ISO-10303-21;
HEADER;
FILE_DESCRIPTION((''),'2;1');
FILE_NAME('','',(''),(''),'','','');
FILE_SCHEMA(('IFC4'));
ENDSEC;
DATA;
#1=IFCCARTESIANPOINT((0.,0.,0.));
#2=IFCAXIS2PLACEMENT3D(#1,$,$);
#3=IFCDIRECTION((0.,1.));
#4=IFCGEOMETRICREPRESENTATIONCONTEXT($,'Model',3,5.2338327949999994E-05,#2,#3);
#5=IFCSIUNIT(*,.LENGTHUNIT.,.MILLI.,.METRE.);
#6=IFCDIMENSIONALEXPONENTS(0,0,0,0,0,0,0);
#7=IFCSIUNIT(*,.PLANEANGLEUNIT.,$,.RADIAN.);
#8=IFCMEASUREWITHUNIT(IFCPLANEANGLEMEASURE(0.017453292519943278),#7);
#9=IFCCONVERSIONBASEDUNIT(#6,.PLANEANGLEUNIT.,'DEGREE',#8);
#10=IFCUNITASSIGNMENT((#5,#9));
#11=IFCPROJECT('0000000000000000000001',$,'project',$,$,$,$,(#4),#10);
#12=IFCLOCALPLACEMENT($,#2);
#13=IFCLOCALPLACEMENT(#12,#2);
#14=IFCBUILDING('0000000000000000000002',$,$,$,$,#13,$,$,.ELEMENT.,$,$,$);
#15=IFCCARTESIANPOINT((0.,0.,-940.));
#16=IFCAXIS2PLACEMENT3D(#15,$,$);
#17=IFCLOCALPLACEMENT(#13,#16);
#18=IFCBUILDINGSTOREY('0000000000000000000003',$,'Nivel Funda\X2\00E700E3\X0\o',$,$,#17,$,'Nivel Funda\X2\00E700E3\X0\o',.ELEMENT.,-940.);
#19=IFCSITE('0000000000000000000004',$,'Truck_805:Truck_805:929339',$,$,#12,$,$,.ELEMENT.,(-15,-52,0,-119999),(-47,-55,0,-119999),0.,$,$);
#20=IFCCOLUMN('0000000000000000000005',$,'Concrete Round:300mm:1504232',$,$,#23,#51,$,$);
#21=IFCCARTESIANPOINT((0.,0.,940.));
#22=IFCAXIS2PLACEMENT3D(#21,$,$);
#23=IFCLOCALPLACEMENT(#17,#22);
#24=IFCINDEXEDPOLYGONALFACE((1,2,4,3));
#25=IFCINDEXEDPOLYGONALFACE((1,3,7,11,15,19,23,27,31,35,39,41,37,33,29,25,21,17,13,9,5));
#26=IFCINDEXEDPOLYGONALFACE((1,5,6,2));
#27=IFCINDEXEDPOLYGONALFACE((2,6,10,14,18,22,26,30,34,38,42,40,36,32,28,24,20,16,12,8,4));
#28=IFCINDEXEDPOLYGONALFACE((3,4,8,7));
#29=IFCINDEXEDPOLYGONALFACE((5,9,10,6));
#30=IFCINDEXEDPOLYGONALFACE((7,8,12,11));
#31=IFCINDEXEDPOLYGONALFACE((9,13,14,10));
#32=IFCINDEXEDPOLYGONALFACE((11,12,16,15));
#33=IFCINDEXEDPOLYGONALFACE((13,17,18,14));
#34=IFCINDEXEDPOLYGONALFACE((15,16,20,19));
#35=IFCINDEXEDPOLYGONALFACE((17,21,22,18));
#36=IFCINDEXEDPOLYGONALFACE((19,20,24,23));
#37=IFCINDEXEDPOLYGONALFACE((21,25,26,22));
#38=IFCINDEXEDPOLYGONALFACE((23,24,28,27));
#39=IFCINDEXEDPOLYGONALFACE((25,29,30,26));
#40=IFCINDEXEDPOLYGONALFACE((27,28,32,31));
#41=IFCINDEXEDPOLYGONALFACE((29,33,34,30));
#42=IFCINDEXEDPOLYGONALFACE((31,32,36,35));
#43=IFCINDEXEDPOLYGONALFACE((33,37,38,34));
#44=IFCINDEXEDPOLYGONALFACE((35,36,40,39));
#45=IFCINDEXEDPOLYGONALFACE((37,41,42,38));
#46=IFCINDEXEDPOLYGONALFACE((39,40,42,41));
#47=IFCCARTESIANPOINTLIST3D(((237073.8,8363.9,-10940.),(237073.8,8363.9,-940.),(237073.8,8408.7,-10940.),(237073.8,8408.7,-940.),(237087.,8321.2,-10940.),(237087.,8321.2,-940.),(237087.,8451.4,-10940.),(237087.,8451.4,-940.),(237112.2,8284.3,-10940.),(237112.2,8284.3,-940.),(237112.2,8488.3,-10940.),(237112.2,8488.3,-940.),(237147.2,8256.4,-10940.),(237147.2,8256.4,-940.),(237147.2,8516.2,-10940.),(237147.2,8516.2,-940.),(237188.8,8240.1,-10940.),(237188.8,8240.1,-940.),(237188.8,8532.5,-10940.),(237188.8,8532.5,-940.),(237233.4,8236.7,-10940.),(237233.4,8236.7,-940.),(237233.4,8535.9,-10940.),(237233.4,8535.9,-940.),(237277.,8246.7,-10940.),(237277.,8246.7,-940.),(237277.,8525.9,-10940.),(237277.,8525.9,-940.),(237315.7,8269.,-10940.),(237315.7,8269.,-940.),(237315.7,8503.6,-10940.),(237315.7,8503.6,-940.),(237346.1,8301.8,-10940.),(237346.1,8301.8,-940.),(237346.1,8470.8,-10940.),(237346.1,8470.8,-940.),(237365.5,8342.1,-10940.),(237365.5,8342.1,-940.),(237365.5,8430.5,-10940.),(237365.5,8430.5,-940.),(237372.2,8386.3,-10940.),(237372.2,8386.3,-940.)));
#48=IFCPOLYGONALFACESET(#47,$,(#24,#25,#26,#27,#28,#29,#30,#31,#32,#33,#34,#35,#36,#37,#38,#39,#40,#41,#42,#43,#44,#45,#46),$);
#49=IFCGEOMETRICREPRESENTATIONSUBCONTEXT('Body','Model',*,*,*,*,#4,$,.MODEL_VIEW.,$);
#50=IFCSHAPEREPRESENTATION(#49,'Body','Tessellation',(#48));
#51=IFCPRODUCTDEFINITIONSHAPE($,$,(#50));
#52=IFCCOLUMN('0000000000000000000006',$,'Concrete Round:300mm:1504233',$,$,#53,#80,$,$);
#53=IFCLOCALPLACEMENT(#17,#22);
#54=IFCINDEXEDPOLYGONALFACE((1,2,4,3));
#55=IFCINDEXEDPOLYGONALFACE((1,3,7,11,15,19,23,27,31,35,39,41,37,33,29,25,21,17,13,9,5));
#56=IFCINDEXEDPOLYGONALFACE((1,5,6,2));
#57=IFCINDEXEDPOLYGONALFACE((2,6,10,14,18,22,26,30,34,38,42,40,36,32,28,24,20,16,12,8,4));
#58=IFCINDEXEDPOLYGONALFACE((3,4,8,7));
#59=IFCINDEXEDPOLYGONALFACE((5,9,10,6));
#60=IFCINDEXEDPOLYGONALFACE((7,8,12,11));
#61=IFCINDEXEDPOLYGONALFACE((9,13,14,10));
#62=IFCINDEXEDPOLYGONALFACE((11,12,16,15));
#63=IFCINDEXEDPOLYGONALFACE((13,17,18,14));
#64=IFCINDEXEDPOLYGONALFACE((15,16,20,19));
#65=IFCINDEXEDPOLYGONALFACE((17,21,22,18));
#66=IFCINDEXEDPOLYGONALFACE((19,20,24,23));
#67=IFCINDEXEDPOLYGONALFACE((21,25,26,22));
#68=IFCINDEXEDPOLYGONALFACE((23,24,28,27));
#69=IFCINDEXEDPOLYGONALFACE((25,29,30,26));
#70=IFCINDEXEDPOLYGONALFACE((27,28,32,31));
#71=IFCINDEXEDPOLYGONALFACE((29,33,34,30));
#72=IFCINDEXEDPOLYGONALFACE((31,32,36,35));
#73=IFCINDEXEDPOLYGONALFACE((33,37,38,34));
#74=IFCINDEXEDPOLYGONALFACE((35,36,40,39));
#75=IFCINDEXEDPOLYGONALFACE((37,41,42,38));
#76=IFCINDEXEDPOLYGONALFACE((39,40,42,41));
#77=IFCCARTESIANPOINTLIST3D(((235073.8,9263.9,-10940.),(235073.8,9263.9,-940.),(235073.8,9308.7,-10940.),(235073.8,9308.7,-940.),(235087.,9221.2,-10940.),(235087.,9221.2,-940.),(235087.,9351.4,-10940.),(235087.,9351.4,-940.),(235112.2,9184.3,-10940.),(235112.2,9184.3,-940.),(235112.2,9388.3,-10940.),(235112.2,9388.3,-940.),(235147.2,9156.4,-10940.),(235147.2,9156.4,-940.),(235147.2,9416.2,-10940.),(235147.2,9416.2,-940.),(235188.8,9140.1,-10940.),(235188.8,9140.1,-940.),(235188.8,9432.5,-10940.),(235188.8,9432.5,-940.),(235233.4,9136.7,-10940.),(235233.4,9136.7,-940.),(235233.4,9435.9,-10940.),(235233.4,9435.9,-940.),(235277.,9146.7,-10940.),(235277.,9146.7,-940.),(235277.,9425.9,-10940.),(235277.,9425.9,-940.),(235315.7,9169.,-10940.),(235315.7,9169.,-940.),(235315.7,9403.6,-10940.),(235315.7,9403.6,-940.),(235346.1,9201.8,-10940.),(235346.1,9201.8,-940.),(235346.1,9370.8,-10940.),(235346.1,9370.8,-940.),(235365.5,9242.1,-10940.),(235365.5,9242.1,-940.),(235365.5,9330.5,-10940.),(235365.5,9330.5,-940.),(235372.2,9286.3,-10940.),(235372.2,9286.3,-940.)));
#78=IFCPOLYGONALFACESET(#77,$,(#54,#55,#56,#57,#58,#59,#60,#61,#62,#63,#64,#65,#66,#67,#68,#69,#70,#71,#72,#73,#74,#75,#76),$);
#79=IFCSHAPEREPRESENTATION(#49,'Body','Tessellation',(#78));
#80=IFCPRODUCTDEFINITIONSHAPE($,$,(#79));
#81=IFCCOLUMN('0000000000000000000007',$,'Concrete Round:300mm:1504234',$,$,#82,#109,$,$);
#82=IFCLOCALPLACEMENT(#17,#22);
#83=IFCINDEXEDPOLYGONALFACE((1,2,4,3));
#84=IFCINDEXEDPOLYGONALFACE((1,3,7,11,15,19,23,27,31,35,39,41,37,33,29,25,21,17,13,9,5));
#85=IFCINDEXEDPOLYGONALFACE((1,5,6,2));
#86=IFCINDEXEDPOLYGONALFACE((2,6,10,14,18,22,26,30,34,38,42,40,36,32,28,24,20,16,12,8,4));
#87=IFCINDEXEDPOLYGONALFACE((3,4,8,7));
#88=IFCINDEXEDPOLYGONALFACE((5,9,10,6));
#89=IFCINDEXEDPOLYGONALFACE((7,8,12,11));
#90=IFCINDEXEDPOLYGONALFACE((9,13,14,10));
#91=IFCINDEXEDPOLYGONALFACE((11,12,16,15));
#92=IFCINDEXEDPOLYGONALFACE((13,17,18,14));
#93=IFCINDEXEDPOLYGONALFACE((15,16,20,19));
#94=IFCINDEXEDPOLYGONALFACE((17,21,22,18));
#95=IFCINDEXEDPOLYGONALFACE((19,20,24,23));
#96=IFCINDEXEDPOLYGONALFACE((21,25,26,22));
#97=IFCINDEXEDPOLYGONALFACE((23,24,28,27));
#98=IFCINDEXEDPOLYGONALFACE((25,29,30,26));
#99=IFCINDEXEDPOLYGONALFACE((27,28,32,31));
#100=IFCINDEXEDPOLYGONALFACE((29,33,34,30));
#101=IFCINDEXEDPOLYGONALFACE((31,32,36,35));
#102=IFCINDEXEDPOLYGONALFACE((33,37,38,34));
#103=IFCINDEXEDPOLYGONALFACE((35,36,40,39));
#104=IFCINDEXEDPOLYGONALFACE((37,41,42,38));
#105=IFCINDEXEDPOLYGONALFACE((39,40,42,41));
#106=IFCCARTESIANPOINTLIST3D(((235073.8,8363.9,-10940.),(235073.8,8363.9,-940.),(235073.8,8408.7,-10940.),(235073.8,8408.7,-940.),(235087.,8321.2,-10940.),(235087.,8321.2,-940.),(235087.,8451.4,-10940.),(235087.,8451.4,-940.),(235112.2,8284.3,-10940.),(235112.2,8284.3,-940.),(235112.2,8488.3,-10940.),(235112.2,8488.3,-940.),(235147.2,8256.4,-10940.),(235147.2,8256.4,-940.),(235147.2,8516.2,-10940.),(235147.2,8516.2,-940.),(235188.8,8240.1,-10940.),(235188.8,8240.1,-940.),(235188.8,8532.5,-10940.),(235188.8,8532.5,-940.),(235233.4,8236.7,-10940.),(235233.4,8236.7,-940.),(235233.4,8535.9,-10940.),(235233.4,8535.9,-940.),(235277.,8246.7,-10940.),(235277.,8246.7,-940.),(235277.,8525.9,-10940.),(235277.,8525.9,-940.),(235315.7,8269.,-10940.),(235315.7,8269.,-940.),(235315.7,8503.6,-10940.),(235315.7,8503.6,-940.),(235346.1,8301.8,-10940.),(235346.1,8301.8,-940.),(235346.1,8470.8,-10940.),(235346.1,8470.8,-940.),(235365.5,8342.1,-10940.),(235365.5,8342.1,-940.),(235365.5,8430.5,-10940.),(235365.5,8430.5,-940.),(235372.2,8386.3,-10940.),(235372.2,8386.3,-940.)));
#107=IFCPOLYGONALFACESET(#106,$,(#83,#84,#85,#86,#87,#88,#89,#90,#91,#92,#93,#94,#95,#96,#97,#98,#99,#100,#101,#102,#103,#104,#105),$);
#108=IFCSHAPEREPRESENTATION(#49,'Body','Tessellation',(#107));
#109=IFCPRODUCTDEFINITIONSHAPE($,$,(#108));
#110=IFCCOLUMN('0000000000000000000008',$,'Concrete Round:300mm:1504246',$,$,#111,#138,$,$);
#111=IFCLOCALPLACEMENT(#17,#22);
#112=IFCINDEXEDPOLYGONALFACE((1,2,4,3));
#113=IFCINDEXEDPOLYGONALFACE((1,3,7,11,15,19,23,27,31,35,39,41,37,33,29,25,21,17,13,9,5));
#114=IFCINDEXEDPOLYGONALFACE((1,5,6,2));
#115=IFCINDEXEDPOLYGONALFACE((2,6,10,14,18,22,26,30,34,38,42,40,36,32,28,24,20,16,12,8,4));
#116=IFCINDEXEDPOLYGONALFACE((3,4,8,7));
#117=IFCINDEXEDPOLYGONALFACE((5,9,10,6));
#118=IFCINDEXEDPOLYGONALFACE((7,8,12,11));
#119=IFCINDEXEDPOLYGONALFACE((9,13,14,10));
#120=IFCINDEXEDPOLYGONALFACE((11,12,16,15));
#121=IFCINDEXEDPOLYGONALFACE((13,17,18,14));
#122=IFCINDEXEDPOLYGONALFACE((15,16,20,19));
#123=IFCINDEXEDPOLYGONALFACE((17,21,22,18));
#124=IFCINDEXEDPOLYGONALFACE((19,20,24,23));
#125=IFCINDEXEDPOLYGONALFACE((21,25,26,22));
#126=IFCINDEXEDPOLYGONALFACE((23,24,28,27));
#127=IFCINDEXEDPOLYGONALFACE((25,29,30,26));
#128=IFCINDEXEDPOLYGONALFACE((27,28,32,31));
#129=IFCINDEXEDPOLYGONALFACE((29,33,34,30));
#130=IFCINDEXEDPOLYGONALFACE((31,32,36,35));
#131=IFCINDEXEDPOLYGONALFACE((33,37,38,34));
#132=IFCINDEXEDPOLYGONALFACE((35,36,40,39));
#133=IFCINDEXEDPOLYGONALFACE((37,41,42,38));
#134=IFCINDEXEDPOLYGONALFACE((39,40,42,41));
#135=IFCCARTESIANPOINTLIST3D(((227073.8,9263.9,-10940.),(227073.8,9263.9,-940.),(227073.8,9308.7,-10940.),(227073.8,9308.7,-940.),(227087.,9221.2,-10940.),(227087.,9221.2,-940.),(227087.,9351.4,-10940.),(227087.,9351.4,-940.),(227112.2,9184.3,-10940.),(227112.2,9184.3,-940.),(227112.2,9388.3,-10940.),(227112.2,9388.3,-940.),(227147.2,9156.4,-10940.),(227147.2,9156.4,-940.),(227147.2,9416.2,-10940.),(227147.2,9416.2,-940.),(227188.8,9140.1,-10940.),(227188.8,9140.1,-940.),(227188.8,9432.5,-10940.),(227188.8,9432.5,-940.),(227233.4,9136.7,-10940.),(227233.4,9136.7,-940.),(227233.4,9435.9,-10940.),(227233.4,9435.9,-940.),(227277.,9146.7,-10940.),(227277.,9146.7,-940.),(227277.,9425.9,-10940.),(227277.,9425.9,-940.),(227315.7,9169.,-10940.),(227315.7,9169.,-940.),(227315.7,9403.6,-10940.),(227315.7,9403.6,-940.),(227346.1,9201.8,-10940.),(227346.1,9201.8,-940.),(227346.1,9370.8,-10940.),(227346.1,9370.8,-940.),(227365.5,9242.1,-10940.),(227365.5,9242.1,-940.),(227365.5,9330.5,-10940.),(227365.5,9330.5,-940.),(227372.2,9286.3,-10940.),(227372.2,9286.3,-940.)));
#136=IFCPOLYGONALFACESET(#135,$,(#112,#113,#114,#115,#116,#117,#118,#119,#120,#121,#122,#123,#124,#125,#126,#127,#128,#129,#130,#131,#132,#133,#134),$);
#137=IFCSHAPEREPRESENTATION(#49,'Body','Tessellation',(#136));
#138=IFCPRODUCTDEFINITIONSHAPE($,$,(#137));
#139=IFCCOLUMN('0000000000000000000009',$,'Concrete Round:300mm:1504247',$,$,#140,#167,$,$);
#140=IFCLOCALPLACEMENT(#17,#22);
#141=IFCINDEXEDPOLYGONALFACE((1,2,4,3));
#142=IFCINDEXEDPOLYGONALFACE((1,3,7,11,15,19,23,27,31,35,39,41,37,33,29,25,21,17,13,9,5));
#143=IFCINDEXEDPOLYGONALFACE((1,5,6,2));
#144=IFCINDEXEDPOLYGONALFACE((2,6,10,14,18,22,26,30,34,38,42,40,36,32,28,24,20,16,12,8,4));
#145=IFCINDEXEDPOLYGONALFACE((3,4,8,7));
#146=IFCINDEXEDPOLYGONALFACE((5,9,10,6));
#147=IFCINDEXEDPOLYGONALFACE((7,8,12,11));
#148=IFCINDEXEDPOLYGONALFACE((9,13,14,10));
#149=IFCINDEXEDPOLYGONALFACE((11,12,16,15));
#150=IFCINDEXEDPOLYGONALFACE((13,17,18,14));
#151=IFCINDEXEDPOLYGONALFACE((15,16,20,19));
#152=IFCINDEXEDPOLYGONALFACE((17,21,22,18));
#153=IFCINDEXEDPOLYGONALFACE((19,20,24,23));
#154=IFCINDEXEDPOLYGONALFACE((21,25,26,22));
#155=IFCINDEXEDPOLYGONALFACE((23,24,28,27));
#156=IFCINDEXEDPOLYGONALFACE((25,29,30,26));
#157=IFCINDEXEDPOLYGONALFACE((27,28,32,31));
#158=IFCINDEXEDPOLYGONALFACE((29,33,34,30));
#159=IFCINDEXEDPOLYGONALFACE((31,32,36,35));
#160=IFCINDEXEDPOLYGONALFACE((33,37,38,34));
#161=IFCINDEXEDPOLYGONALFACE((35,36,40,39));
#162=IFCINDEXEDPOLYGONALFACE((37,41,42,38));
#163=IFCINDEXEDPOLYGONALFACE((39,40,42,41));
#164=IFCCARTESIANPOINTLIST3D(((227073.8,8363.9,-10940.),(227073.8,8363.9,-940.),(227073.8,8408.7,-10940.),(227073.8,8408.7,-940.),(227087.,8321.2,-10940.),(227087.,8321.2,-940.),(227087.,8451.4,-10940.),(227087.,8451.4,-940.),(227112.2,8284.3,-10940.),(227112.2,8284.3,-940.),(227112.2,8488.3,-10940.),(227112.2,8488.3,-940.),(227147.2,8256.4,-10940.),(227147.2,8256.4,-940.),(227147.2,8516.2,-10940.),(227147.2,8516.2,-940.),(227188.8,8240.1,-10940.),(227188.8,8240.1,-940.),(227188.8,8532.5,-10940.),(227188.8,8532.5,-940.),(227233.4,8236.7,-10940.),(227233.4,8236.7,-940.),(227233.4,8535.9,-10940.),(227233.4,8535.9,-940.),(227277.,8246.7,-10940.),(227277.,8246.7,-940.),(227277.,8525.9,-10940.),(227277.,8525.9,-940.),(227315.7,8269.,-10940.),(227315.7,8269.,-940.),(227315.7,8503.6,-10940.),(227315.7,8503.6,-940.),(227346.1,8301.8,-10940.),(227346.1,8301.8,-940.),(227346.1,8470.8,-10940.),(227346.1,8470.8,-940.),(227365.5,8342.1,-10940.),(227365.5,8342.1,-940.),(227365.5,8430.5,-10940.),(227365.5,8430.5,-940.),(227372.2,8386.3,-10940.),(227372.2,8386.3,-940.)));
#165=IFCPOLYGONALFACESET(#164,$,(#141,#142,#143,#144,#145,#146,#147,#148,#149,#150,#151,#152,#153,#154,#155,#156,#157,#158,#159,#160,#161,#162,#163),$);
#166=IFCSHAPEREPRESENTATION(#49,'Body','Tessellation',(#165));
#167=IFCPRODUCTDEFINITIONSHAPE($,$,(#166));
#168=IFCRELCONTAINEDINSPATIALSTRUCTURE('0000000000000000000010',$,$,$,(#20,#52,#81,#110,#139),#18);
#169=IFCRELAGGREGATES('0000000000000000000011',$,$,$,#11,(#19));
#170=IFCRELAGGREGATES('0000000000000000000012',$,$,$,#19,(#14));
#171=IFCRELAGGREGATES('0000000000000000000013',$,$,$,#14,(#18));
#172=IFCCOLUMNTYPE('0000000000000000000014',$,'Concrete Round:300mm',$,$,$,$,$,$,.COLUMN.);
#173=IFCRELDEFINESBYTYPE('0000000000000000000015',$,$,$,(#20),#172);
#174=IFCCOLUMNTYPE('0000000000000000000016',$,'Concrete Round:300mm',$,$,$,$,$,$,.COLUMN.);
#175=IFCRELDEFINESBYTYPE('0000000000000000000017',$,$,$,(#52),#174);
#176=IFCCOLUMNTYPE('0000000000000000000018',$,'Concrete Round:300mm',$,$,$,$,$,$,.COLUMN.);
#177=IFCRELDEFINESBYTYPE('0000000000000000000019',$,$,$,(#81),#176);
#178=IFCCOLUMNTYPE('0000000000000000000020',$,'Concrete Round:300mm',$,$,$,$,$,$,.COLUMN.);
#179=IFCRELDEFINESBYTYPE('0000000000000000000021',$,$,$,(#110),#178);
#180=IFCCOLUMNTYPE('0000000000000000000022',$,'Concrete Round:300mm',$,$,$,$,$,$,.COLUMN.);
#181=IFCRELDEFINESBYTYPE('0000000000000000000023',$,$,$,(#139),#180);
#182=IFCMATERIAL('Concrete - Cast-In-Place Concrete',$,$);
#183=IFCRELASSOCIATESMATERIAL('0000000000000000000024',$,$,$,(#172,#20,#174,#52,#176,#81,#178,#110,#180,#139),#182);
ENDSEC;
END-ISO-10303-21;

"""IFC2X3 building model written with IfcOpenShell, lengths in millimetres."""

from ifc_helpers import new_model, entity, si_unit, converted_unit, direction, frame, origin, origin_2d_with_axis, place, context, subcontext, project, spatial, circle, extrude, source, transform, mapped, material, type_object, type_shapes, element, save


model = new_model("IFC2X3")

# Units and contexts
model_context = context("Model", 3, precision=5.2338327949999994e-05, world=origin(), true_north=direction((0.0, 1.0)))
body_context = subcontext(model_context, "Body", "Model", "MODEL_VIEW")
ifc_project = project(units=[si_unit("LENGTHUNIT", "METRE", prefix="MILLI"), converted_unit("PLANEANGLEUNIT", "DEGREE", entity("IfcPlaneAngleMeasure", 0.017453292519943278), si_unit("PLANEANGLEUNIT", "RADIAN"), dimensions=[0, 0, 0, 0, 0, 0, 0])], contexts=[model_context])

# Site, building, storey
site_placement = place(None, origin())
site = spatial("IfcSite", under=ifc_project, at=site_placement, Name="Truck_805:Truck_805:929339", CompositionType="ELEMENT", RefLatitude=(-15, -52, 0, -119999), RefLongitude=(-47, -55, 0, -119999), RefElevation=0.0)
building_placement = place(site_placement, origin())
building = spatial("IfcBuilding", under=site, at=building_placement, CompositionType="ELEMENT")
storey_placement = place(building_placement, frame((0.0, 0.0, -940.0)))
storey = spatial("IfcBuildingStorey", under=building, at=storey_placement, Name="Nivel Fundação", LongName="Nivel Fundação", CompositionType="ELEMENT", Elevation=-940.0)

# Columns
ifc_material = material(Name="Concrete - Cast-In-Place Concrete")
column_type_1 = type_object("IfcColumnType", Name="Concrete Round:300mm", PredefinedType="COLUMN", material=ifc_material)
shared_shape_1 = source(origin(), body_context, "Body", "SweptSolid", [
    extrude(circle(Radius=150.0, at=origin_2d_with_axis()), frame((237222.2, 8386.3, -10940.0)), (0.0, 0.0, 1.0), 10000.0),
])
type_shapes(column_type_1, [shared_shape_1])
column_1_placement = place(storey_placement, frame((0.0, 0.0, 940.0)))
element("IfcColumn", 1, at=column_1_placement, inside=storey, type_object=column_type_1, material=ifc_material, Name="Concrete Round:300mm:1504232", context=body_context, shape_type="MappedRepresentation", body=[
    mapped(shared_shape_1, transform((0.0, 0.0, 0.0), scale=1.0)),
])
column_type_2 = type_object("IfcColumnType", Name="Concrete Round:300mm", PredefinedType="COLUMN", material=ifc_material)
shared_shape_2 = source(origin(), body_context, "Body", "SweptSolid", [
    extrude(circle(Radius=150.0, at=origin_2d_with_axis()), frame((235222.2, 9286.3, -10940.0)), (0.0, 0.0, 1.0), 10000.0),
])
type_shapes(column_type_2, [shared_shape_2])
column_2_placement = place(storey_placement, frame((0.0, 0.0, 940.0)))
element("IfcColumn", 2, at=column_2_placement, inside=storey, type_object=column_type_2, material=ifc_material, Name="Concrete Round:300mm:1504233", context=body_context, shape_type="MappedRepresentation", body=[
    mapped(shared_shape_2, transform((0.0, 0.0, 0.0), scale=1.0)),
])
column_type_3 = type_object("IfcColumnType", Name="Concrete Round:300mm", PredefinedType="COLUMN", material=ifc_material)
shared_shape_3 = source(origin(), body_context, "Body", "SweptSolid", [
    extrude(circle(Radius=150.0, at=origin_2d_with_axis()), frame((235222.2, 8386.3, -10940.0)), (0.0, 0.0, 1.0), 10000.0),
])
type_shapes(column_type_3, [shared_shape_3])
column_3_placement = place(storey_placement, frame((0.0, 0.0, 940.0)))
element("IfcColumn", 3, at=column_3_placement, inside=storey, type_object=column_type_3, material=ifc_material, Name="Concrete Round:300mm:1504234", context=body_context, shape_type="MappedRepresentation", body=[
    mapped(shared_shape_3, transform((0.0, 0.0, 0.0), scale=1.0)),
])
column_type_4 = type_object("IfcColumnType", Name="Concrete Round:300mm", PredefinedType="COLUMN", material=ifc_material)
shared_shape_4 = source(origin(), body_context, "Body", "SweptSolid", [
    extrude(circle(Radius=150.0, at=origin_2d_with_axis()), frame((227222.2, 9286.3, -10940.0)), (0.0, 0.0, 1.0), 10000.0),
])
type_shapes(column_type_4, [shared_shape_4])
column_4_placement = place(storey_placement, frame((0.0, 0.0, 940.0)))
element("IfcColumn", 4, at=column_4_placement, inside=storey, type_object=column_type_4, material=ifc_material, Name="Concrete Round:300mm:1504246", context=body_context, shape_type="MappedRepresentation", body=[
    mapped(shared_shape_4, transform((0.0, 0.0, 0.0), scale=1.0)),
])
column_type_5 = type_object("IfcColumnType", Name="Concrete Round:300mm", PredefinedType="COLUMN", material=ifc_material)
shared_shape_5 = source(origin(), body_context, "Body", "SweptSolid", [
    extrude(circle(Radius=150.0, at=origin_2d_with_axis()), frame((227222.2, 8386.3, -10940.0)), (0.0, 0.0, 1.0), 10000.0),
])
type_shapes(column_type_5, [shared_shape_5])
column_5_placement = place(storey_placement, frame((0.0, 0.0, 940.0)))
element("IfcColumn", 5, at=column_5_placement, inside=storey, type_object=column_type_5, material=ifc_material, Name="Concrete Round:300mm:1504247", context=body_context, shape_type="MappedRepresentation", body=[
    mapped(shared_shape_5, transform((0.0, 0.0, 0.0), scale=1.0)),
])

save(model, "model.ifc")
